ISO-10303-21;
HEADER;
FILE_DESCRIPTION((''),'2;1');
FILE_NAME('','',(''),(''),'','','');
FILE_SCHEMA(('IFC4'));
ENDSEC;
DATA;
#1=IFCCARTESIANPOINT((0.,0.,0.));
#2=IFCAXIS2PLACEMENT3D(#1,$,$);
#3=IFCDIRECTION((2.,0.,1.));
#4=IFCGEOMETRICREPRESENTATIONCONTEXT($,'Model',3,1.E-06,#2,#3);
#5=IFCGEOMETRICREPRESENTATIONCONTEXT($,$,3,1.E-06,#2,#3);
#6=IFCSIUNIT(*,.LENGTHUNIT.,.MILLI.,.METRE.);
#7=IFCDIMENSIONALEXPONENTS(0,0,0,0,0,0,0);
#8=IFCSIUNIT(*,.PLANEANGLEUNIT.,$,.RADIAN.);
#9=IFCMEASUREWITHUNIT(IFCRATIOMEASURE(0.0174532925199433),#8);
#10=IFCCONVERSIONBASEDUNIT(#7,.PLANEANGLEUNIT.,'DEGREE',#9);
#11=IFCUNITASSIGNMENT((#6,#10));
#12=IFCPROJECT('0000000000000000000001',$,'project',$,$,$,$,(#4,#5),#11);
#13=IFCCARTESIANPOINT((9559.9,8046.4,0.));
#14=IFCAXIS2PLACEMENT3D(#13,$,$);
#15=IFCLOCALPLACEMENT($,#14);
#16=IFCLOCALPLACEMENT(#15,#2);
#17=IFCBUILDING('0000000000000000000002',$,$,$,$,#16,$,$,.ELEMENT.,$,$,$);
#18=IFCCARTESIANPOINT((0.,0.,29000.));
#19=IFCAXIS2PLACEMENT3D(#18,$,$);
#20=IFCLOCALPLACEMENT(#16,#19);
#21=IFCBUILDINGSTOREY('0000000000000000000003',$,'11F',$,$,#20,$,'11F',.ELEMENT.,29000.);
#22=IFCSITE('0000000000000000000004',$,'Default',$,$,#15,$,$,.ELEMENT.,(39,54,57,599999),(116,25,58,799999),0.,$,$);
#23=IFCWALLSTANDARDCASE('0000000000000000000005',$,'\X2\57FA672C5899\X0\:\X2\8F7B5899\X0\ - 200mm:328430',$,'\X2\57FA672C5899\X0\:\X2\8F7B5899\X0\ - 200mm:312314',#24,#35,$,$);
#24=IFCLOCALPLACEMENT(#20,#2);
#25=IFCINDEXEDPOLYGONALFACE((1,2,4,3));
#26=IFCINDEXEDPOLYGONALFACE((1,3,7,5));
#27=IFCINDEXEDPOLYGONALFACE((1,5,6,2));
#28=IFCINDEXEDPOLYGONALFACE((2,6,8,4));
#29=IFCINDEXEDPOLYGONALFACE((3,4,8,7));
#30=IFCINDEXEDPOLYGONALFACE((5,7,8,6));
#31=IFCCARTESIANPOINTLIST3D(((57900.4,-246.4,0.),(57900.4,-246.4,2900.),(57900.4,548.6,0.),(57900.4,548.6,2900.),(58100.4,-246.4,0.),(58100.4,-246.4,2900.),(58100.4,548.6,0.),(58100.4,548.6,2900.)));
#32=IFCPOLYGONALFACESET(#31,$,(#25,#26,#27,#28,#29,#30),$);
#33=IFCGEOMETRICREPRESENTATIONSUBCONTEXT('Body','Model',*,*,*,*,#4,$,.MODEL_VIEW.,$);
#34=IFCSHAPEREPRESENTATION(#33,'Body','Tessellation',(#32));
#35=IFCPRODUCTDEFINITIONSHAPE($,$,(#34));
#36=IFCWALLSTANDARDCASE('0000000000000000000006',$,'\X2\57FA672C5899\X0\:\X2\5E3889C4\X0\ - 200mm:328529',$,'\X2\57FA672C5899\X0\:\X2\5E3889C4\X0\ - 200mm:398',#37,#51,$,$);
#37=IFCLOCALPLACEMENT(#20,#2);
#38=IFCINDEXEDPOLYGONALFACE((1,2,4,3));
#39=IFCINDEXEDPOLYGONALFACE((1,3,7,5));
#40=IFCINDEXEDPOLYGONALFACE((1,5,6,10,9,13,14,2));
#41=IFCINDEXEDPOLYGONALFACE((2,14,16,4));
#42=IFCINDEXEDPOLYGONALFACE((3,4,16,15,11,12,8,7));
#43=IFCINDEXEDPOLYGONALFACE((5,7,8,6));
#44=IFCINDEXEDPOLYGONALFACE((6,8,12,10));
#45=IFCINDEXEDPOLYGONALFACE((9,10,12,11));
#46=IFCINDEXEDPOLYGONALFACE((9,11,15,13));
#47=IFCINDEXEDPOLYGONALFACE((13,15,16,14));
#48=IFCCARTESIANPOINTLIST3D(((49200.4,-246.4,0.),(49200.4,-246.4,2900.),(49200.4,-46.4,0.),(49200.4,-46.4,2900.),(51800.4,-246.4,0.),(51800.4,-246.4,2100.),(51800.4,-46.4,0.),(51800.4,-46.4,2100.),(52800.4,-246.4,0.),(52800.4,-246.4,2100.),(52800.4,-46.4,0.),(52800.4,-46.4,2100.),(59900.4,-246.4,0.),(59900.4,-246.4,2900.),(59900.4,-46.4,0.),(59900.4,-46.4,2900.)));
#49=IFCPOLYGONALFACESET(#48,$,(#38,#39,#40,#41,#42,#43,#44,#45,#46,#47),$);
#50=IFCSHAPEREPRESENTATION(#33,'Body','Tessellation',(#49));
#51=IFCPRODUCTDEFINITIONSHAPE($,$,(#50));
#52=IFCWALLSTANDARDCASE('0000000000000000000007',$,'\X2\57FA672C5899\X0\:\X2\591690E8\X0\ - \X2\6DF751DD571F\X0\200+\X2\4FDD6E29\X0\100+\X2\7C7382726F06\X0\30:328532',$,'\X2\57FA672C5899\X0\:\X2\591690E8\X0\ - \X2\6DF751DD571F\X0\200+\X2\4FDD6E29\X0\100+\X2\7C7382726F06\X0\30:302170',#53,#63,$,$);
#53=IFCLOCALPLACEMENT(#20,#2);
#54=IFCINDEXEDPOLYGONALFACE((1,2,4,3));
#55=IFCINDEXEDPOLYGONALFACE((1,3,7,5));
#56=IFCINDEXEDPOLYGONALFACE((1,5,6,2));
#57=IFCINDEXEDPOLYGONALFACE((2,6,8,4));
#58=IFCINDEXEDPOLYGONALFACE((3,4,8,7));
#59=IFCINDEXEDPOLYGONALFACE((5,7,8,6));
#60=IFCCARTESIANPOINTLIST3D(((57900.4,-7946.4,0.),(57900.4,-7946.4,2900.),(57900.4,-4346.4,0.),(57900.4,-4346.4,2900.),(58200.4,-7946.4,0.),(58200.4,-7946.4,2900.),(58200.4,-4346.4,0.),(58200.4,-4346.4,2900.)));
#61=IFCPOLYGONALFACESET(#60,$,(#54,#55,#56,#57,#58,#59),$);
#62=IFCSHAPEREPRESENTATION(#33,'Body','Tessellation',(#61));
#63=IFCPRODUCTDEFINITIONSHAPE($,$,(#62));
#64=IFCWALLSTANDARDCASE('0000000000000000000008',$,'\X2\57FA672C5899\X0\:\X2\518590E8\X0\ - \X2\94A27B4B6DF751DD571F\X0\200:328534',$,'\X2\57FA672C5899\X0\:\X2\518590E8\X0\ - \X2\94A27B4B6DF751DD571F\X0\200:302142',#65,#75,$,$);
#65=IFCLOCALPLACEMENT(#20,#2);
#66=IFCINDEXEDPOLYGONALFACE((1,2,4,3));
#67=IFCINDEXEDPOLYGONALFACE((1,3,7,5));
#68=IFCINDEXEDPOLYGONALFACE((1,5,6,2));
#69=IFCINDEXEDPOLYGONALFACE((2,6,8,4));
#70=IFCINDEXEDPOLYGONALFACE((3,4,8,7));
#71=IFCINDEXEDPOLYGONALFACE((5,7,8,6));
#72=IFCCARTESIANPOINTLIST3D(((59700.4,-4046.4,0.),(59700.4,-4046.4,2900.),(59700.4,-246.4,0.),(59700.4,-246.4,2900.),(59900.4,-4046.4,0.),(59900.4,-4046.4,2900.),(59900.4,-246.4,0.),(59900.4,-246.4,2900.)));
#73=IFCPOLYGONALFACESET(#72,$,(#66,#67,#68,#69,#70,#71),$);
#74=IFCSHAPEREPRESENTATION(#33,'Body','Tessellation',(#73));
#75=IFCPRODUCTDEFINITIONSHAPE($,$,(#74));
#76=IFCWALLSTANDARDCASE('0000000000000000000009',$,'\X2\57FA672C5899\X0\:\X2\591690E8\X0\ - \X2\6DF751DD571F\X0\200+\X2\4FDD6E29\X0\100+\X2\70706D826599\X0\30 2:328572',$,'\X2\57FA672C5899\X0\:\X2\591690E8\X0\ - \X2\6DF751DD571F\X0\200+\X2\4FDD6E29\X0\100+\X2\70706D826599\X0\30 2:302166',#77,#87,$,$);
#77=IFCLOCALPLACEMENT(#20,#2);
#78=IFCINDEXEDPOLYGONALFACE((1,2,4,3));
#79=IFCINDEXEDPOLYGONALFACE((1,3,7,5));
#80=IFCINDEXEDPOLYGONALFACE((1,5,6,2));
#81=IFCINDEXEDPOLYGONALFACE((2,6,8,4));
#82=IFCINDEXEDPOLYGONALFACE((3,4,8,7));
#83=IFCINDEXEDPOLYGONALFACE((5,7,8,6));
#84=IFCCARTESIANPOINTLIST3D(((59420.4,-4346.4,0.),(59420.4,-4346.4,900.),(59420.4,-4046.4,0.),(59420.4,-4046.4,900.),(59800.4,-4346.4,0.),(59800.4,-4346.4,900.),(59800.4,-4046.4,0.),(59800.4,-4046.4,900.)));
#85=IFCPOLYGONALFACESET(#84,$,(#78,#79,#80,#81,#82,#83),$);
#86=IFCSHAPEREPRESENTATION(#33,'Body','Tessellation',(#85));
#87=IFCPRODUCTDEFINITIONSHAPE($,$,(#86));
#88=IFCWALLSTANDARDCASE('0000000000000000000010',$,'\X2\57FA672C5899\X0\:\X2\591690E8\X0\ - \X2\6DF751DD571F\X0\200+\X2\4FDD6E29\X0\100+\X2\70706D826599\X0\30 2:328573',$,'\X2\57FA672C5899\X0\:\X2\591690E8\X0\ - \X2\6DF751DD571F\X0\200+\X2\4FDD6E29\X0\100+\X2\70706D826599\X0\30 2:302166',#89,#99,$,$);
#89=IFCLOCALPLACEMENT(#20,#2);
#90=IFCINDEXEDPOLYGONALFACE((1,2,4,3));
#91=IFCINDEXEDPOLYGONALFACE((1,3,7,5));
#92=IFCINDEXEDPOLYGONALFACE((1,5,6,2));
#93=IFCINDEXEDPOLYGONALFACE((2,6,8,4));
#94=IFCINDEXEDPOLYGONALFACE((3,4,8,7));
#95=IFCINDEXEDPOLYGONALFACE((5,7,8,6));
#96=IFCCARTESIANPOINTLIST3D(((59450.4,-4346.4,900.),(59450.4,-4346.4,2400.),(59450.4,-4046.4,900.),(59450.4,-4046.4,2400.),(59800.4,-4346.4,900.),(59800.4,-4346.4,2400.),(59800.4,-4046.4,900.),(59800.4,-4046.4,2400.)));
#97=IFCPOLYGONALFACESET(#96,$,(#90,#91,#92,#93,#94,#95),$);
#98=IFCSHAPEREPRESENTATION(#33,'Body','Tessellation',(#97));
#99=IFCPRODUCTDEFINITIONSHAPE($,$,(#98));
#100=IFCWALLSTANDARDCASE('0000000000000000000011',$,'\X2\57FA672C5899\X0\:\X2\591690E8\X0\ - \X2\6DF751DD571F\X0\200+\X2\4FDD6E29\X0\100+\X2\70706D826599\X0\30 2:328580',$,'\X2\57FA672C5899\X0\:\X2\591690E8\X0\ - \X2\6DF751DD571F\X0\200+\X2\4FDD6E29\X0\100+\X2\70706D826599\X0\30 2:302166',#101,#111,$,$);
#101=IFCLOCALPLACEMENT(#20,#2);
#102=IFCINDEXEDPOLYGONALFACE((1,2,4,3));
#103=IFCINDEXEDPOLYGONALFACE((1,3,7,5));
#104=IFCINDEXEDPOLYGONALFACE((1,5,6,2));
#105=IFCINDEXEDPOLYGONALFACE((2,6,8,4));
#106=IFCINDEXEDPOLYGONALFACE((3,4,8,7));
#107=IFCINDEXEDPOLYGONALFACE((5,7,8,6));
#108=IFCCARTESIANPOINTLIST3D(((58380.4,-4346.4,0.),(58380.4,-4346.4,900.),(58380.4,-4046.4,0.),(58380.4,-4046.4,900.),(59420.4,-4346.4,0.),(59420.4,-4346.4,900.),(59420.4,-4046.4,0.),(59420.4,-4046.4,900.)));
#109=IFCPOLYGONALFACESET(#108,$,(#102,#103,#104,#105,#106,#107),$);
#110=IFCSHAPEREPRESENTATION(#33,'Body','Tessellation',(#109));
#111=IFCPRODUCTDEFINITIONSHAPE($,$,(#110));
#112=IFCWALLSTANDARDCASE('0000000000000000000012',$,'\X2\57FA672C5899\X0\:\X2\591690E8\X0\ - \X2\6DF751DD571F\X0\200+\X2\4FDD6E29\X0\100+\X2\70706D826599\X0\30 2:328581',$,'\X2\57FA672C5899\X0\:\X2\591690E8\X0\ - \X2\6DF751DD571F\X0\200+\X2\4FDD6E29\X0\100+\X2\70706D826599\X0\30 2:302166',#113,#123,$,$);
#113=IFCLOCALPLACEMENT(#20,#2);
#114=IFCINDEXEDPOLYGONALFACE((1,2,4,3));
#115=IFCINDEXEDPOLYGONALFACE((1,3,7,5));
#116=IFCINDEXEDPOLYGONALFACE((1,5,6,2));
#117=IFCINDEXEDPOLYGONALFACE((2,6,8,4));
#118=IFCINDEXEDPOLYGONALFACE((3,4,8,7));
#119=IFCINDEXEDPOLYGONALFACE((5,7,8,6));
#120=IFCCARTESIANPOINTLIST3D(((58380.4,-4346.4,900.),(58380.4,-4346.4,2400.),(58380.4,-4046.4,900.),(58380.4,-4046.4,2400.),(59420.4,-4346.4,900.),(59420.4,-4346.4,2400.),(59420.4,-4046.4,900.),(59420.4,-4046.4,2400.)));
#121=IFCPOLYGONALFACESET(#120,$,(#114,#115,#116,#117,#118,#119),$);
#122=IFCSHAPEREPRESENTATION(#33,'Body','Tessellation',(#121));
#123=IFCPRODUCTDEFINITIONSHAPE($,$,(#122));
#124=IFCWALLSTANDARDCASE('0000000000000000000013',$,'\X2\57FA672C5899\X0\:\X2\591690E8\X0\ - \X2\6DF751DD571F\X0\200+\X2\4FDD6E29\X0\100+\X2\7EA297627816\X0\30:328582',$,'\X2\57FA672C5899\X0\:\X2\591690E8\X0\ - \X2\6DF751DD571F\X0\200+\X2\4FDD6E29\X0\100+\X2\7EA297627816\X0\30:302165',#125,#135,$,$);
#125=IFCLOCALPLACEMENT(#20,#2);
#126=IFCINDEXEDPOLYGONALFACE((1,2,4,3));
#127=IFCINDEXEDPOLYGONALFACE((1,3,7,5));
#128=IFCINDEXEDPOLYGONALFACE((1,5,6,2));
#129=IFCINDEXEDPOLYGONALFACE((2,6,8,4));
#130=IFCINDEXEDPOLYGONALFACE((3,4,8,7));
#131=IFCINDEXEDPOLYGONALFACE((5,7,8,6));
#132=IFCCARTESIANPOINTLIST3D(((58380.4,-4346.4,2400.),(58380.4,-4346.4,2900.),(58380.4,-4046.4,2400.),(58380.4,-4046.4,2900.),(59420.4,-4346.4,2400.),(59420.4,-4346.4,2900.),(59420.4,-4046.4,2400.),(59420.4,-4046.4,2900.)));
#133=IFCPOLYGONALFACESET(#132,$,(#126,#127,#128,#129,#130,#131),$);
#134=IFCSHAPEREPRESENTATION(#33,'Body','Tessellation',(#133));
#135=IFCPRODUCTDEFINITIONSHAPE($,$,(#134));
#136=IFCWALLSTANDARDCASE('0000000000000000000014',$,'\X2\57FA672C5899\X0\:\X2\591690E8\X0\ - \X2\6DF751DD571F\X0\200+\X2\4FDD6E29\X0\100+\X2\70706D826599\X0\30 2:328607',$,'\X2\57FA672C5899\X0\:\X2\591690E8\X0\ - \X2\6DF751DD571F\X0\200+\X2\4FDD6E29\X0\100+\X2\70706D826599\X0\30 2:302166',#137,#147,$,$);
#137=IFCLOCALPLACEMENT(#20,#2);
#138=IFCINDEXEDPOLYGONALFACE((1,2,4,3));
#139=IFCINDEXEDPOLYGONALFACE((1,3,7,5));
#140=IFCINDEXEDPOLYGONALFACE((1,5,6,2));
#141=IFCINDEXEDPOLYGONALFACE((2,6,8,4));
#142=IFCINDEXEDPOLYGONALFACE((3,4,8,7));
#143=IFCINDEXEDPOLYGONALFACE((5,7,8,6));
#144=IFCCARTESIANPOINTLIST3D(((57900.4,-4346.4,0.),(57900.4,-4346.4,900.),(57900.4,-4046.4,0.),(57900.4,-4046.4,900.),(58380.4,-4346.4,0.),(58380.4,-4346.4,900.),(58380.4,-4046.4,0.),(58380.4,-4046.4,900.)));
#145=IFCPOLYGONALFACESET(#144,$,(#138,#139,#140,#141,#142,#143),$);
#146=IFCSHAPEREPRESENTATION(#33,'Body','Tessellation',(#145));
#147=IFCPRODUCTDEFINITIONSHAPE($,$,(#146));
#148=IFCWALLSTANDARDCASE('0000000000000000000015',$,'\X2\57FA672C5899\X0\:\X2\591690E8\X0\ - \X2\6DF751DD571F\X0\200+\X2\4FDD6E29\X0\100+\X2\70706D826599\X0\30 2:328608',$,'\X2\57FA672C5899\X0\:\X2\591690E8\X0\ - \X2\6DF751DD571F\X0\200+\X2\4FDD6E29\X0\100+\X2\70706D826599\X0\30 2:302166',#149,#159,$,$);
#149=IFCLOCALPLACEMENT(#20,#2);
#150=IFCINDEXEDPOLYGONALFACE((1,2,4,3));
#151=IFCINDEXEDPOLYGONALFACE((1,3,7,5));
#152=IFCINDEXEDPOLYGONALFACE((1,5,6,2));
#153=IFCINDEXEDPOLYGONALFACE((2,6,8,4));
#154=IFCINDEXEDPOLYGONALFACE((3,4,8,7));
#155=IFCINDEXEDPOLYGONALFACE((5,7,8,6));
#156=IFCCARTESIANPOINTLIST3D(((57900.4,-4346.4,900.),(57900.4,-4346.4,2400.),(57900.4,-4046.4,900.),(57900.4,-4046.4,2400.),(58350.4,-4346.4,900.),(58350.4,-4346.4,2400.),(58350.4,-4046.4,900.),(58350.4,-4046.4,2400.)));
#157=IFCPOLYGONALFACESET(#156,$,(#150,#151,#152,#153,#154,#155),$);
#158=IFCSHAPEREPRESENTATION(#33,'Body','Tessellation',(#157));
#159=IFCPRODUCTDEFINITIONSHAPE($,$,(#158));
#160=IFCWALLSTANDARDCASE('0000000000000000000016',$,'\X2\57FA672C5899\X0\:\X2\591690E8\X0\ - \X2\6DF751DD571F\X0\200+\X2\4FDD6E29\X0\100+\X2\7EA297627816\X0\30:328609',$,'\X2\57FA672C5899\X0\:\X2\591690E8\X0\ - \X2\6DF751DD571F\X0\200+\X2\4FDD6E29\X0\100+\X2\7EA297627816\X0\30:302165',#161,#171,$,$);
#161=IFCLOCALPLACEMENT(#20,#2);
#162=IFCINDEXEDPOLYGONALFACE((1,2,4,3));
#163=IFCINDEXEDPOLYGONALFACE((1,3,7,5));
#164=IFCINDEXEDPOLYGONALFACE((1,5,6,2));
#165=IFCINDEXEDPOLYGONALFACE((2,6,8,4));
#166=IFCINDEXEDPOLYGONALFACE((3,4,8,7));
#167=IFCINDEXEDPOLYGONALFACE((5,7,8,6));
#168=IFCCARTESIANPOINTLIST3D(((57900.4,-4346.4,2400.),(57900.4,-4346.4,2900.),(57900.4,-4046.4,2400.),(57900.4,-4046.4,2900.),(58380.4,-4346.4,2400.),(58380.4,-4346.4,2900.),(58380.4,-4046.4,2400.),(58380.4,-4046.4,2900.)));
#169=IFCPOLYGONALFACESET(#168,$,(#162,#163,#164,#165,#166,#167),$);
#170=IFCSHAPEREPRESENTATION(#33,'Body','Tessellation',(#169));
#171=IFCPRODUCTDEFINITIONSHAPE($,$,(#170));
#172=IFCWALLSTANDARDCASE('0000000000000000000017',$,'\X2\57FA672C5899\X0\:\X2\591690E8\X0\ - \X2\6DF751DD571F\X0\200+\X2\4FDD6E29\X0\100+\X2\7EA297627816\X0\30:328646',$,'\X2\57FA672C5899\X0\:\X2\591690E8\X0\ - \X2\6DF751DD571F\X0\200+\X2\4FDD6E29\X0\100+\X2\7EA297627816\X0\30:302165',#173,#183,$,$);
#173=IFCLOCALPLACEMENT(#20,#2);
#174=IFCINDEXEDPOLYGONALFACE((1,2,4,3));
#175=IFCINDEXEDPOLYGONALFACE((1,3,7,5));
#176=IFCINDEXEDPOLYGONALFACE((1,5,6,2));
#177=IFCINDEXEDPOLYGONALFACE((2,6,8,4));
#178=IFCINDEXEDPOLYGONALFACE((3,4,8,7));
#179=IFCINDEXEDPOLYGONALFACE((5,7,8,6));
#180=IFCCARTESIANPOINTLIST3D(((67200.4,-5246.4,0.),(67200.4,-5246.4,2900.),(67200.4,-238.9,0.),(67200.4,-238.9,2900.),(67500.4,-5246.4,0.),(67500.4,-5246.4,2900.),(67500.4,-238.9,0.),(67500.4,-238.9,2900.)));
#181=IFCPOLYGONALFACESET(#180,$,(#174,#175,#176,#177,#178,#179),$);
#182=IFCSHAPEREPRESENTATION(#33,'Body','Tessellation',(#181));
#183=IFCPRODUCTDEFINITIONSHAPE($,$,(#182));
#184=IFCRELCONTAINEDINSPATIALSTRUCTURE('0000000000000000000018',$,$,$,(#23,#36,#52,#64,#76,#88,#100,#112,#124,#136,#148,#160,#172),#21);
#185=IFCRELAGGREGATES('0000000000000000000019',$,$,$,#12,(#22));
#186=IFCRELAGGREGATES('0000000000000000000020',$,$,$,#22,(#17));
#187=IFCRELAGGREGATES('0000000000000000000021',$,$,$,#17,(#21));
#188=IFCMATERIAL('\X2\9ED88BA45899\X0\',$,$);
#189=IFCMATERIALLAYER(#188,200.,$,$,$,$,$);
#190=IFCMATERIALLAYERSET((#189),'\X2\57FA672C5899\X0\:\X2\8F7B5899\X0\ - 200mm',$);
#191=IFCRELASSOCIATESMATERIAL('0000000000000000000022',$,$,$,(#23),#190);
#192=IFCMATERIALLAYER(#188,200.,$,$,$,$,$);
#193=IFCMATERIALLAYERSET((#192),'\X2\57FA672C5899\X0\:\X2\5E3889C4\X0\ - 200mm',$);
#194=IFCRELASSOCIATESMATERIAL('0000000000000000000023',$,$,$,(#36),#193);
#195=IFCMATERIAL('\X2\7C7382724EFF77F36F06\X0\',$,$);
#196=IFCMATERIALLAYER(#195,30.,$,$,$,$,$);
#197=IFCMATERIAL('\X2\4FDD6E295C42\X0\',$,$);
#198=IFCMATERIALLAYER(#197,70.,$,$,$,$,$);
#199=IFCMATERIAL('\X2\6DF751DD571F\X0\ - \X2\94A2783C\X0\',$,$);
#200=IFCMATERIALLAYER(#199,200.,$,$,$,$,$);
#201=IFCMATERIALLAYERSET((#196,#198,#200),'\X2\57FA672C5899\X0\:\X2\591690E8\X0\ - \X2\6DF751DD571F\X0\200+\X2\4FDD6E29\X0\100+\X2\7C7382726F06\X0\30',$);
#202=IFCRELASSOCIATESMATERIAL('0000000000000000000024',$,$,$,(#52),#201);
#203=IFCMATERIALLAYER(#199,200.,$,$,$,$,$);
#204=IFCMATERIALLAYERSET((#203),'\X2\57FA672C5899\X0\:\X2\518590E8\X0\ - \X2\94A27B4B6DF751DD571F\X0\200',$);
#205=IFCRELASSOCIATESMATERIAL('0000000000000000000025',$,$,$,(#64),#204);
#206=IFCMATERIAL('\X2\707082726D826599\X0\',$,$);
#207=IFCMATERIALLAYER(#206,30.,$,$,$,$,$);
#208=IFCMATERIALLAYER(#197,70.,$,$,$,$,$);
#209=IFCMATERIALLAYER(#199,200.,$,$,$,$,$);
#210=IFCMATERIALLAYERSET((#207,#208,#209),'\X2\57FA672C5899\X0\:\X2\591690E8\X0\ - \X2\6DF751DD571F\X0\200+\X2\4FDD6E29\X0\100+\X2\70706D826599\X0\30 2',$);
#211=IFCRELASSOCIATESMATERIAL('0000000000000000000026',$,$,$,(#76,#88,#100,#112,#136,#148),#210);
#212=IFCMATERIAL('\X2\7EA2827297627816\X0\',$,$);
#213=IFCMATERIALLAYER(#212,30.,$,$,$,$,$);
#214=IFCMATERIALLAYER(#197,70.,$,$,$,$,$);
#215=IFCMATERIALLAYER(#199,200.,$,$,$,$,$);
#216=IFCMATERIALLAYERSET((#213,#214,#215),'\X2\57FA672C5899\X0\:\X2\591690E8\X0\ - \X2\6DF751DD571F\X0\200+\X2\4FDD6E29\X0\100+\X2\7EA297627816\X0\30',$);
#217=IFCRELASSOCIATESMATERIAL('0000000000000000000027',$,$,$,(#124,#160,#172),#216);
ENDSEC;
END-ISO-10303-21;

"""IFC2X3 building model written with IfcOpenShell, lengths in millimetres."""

from ifc_helpers import new_model, entity, si_unit, converted_unit, direction, frame, frame_2d, origin, place, context, subcontext, project, spatial, rectangle, extrude, material, layer, layer_set, layer_usage, element, save


model = new_model("IFC2X3")

# Units and contexts
model_context = context("Model", 3, precision=1e-06, world=origin(), true_north=direction((2.0, 0.0, 1.0)))
context_of_model = context(None, 3, precision=1e-06, world=origin(), true_north=direction((2.0, 0.0, 1.0)))
body_context = subcontext(model_context, "Body", "Model", "MODEL_VIEW")
ifc_project = project(units=[si_unit("LENGTHUNIT", "METRE", prefix="MILLI"), converted_unit("PLANEANGLEUNIT", "DEGREE", entity("IfcRatioMeasure", 0.0174532925199433), si_unit("PLANEANGLEUNIT", "RADIAN"), dimensions=[0, 0, 0, 0, 0, 0, 0])], contexts=[model_context, context_of_model])

# Site, building, storey
site_placement = place(None, frame((9559.9, 8046.4, 0.0)))
site = spatial("IfcSite", under=ifc_project, at=site_placement, Name="Default", CompositionType="ELEMENT", RefLatitude=(39, 54, 57, 599999), RefLongitude=(116, 25, 58, 799999), RefElevation=0.0)
building_placement = place(site_placement, origin())
building = spatial("IfcBuilding", under=site, at=building_placement, CompositionType="ELEMENT")
storey_placement = place(building_placement, frame((0.0, 0.0, 29000.0)))
storey = spatial("IfcBuildingStorey", under=building, at=storey_placement, Name="11F", LongName="11F", CompositionType="ELEMENT", Elevation=29000.0)

# Wall
ifc_material_1 = material(Name="默认墙")
ifc_layer_1 = layer(ifc_material_1, 200.0)
ifc_layer_set_1 = layer_set([ifc_layer_1], Name="基本墙:轻墙 - 200mm")
ifc_layer_usage_1 = layer_usage(ifc_layer_set_1, "AXIS2", "POSITIVE", -100.0)
wall_1_placement = place(storey_placement, frame((58000.4, -246.4, 0.0), z_axis=(0.0, 0.0, 1.0), x_axis=(0.0, 1.0, 0.0)))
element("IfcWallStandardCase", 1, at=wall_1_placement, inside=storey, material=ifc_layer_usage_1, Name="基本墙:轻墙 - 200mm:328430", ObjectType="基本墙:轻墙 - 200mm:312314", context=body_context, shape_type="SweptSolid", body=[
    extrude(rectangle(XDim=795.0, YDim=200.0, at=frame_2d((397.5, 0.0), x_axis=(-1.0, 0.0))), origin(), (0.0, 0.0, 1.0), 2900.0),
])

# Wall, opening
ifc_layer_2 = layer(ifc_material_1, 200.0)
ifc_layer_set_2 = layer_set([ifc_layer_2], Name="基本墙:常规 - 200mm")
ifc_layer_usage_2 = layer_usage(ifc_layer_set_2, "AXIS2", "POSITIVE", -100.0)
wall_2_placement = place(storey_placement, frame((59900.4, -146.4, 0.0), z_axis=(0.0, 0.0, 1.0), x_axis=(-1.0, 0.0, 0.0)))
wall_2 = element("IfcWallStandardCase", 2, at=wall_2_placement, inside=storey, material=ifc_layer_usage_2, Name="基本墙:常规 - 200mm:328529", ObjectType="基本墙:常规 - 200mm:398", context=body_context, shape_type="SweptSolid", body=[
    extrude(rectangle(XDim=10700.0, YDim=200.0, at=frame_2d((5350.0, 0.0), x_axis=(-1.0, 0.0))), origin(), (0.0, 0.0, 1.0), 2900.0),
])
opening_1_placement = place(wall_2_placement, frame((8100.0, 100.0, 0.0)))
element("IfcOpeningElement", 3, at=opening_1_placement, cuts=wall_2, ObjectType="Opening", context=body_context, shape_type="SweptSolid", body=[
    extrude(rectangle(XDim=2100.0, YDim=1000.0, at=frame_2d((1050.0, 500.0), x_axis=(1.0, 0.0))), frame((0.0, 0.0, 0.0), z_axis=(0.0, -1.0, 0.0), x_axis=(0.0, 0.0, 1.0)), (0.0, 0.0, 1.0), 200.0),
])

# Walls
ifc_material_2 = material(Name="米色仿石漆")
ifc_layer_3 = layer(ifc_material_2, 30.0)
ifc_material_3 = material(Name="保温层")
ifc_layer_4 = layer(ifc_material_3, 70.0)
ifc_material_4 = material(Name="混凝土 - 钢砼")
ifc_layer_5 = layer(ifc_material_4, 200.0)
ifc_layer_set_3 = layer_set([ifc_layer_3, ifc_layer_4, ifc_layer_5], Name="基本墙:外部 - 混凝土200+保温100+米色漆30")
ifc_layer_usage_3 = layer_usage(ifc_layer_set_3, "AXIS2", "POSITIVE", -150.0)
wall_3_placement = place(storey_placement, frame((58050.4, -7946.4, 0.0), z_axis=(0.0, 0.0, 1.0), x_axis=(0.0, 1.0, 0.0)))
element("IfcWallStandardCase", 4, at=wall_3_placement, inside=storey, material=ifc_layer_usage_3, Name="基本墙:外部 - 混凝土200+保温100+米色漆30:328532", ObjectType="基本墙:外部 - 混凝土200+保温100+米色漆30:302170", context=body_context, shape_type="SweptSolid", body=[
    extrude(rectangle(XDim=3600.0, YDim=300.0, at=frame_2d((1800.0, 0.0), x_axis=(-1.0, 0.0))), origin(), (0.0, 0.0, 1.0), 2900.0),
])
ifc_layer_6 = layer(ifc_material_4, 200.0)
ifc_layer_set_4 = layer_set([ifc_layer_6], Name="基本墙:内部 - 钢筋混凝土200")
ifc_layer_usage_4 = layer_usage(ifc_layer_set_4, "AXIS2", "POSITIVE", -100.0)
wall_4_placement = place(storey_placement, frame((59800.4, -4046.4, 0.0), z_axis=(0.0, 0.0, 1.0), x_axis=(0.0, 1.0, 0.0)))
element("IfcWallStandardCase", 5, at=wall_4_placement, inside=storey, material=ifc_layer_usage_4, Name="基本墙:内部 - 钢筋混凝土200:328534", ObjectType="基本墙:内部 - 钢筋混凝土200:302142", context=body_context, shape_type="SweptSolid", body=[
    extrude(rectangle(XDim=3800.0, YDim=200.0, at=frame_2d((1900.0, 0.0), x_axis=(-1.0, 0.0))), origin(), (0.0, 0.0, 1.0), 2900.0),
])
ifc_material_5 = material(Name="灰色涂料")
ifc_layer_7 = layer(ifc_material_5, 30.0)
ifc_layer_8 = layer(ifc_material_3, 70.0)
ifc_layer_9 = layer(ifc_material_4, 200.0)
ifc_layer_set_5 = layer_set([ifc_layer_7, ifc_layer_8, ifc_layer_9], Name="基本墙:外部 - 混凝土200+保温100+灰涂料30 2")
ifc_layer_usage_5 = layer_usage(ifc_layer_set_5, "AXIS2", "POSITIVE", -150.0)
wall_5_placement = place(storey_placement, frame((59420.4, -4196.4, 0.0)))
element("IfcWallStandardCase", 6, at=wall_5_placement, inside=storey, material=ifc_layer_usage_5, Name="基本墙:外部 - 混凝土200+保温100+灰涂料30 2:328572", ObjectType="基本墙:外部 - 混凝土200+保温100+灰涂料30 2:302166", context=body_context, shape_type="SweptSolid", body=[
    extrude(rectangle(XDim=380.0, YDim=300.0, at=frame_2d((190.0, 0.0), x_axis=(-1.0, 0.0))), origin(), (0.0, 0.0, 1.0), 900.0),
])
ifc_layer_usage_6 = layer_usage(ifc_layer_set_5, "AXIS2", "POSITIVE", -150.0)
wall_6_placement = place(storey_placement, frame((59450.4, -4196.4, 900.0)))
element("IfcWallStandardCase", 7, at=wall_6_placement, inside=storey, material=ifc_layer_usage_6, Name="基本墙:外部 - 混凝土200+保温100+灰涂料30 2:328573", ObjectType="基本墙:外部 - 混凝土200+保温100+灰涂料30 2:302166", context=body_context, shape_type="SweptSolid", body=[
    extrude(rectangle(XDim=350.0, YDim=300.0, at=frame_2d((175.0, 0.0), x_axis=(-1.0, 0.0))), origin(), (0.0, 0.0, 1.0), 1500.0),
])

# Shared definitions
ifc_material_6 = material(Name="红色面砖")
ifc_layer_10 = layer(ifc_material_6, 30.0)
ifc_layer_11 = layer(ifc_material_3, 70.0)
ifc_layer_12 = layer(ifc_material_4, 200.0)
ifc_layer_set_6 = layer_set([ifc_layer_10, ifc_layer_11, ifc_layer_12], Name="基本墙:外部 - 混凝土200+保温100+红面砖30")

# Walls
ifc_layer_usage_7 = layer_usage(ifc_layer_set_5, "AXIS2", "POSITIVE", -150.0)
wall_7_placement = place(storey_placement, frame((58380.4, -4196.4, 0.0)))
element("IfcWallStandardCase", 8, at=wall_7_placement, inside=storey, material=ifc_layer_usage_7, Name="基本墙:外部 - 混凝土200+保温100+灰涂料30 2:328580", ObjectType="基本墙:外部 - 混凝土200+保温100+灰涂料30 2:302166", context=body_context, shape_type="SweptSolid", body=[
    extrude(rectangle(XDim=1040.0, YDim=300.0, at=frame_2d((520.0, 0.0), x_axis=(-1.0, 0.0))), origin(), (0.0, 0.0, 1.0), 900.0),
])
ifc_layer_usage_8 = layer_usage(ifc_layer_set_5, "AXIS2", "POSITIVE", -150.0)
wall_8_placement = place(storey_placement, frame((58380.4, -4196.4, 900.0)))
element("IfcWallStandardCase", 9, at=wall_8_placement, inside=storey, material=ifc_layer_usage_8, Name="基本墙:外部 - 混凝土200+保温100+灰涂料30 2:328581", ObjectType="基本墙:外部 - 混凝土200+保温100+灰涂料30 2:302166", context=body_context, shape_type="SweptSolid", body=[
    extrude(rectangle(XDim=1040.0, YDim=300.0, at=frame_2d((520.0, 0.0), x_axis=(-1.0, 0.0))), origin(), (0.0, 0.0, 1.0), 1500.0),
])
ifc_layer_usage_9 = layer_usage(ifc_layer_set_6, "AXIS2", "POSITIVE", -150.0)
wall_9_placement = place(storey_placement, frame((58380.4, -4196.4, 2400.0)))
element("IfcWallStandardCase", 10, at=wall_9_placement, inside=storey, material=ifc_layer_usage_9, Name="基本墙:外部 - 混凝土200+保温100+红面砖30:328582", ObjectType="基本墙:外部 - 混凝土200+保温100+红面砖30:302165", context=body_context, shape_type="SweptSolid", body=[
    extrude(rectangle(XDim=1040.0, YDim=300.0, at=frame_2d((520.0, 0.0), x_axis=(-1.0, 0.0))), origin(), (0.0, 0.0, 1.0), 500.0),
])
ifc_layer_usage_10 = layer_usage(ifc_layer_set_5, "AXIS2", "POSITIVE", -150.0)
wall_10_placement = place(storey_placement, frame((57900.4, -4196.4, 0.0)))
element("IfcWallStandardCase", 11, at=wall_10_placement, inside=storey, material=ifc_layer_usage_10, Name="基本墙:外部 - 混凝土200+保温100+灰涂料30 2:328607", ObjectType="基本墙:外部 - 混凝土200+保温100+灰涂料30 2:302166", context=body_context, shape_type="SweptSolid", body=[
    extrude(rectangle(XDim=480.0, YDim=300.0, at=frame_2d((240.0, 0.0), x_axis=(-1.0, 0.0))), origin(), (0.0, 0.0, 1.0), 900.0),
])
ifc_layer_usage_11 = layer_usage(ifc_layer_set_5, "AXIS2", "POSITIVE", -150.0)
wall_11_placement = place(storey_placement, frame((57900.4, -4196.4, 900.0)))
element("IfcWallStandardCase", 12, at=wall_11_placement, inside=storey, material=ifc_layer_usage_11, Name="基本墙:外部 - 混凝土200+保温100+灰涂料30 2:328608", ObjectType="基本墙:外部 - 混凝土200+保温100+灰涂料30 2:302166", context=body_context, shape_type="SweptSolid", body=[
    extrude(rectangle(XDim=450.0, YDim=300.0, at=frame_2d((225.0, 0.0), x_axis=(-1.0, 0.0))), origin(), (0.0, 0.0, 1.0), 1500.0),
])
ifc_layer_usage_12 = layer_usage(ifc_layer_set_6, "AXIS2", "POSITIVE", -150.0)
wall_12_placement = place(storey_placement, frame((57900.4, -4196.4, 2400.0)))
element("IfcWallStandardCase", 13, at=wall_12_placement, inside=storey, material=ifc_layer_usage_12, Name="基本墙:外部 - 混凝土200+保温100+红面砖30:328609", ObjectType="基本墙:外部 - 混凝土200+保温100+红面砖30:302165", context=body_context, shape_type="SweptSolid", body=[
    extrude(rectangle(XDim=480.0, YDim=300.0, at=frame_2d((240.0, 0.0), x_axis=(-1.0, 0.0))), origin(), (0.0, 0.0, 1.0), 500.0),
])
ifc_layer_usage_13 = layer_usage(ifc_layer_set_6, "AXIS2", "POSITIVE", -150.0)
wall_13_placement = place(storey_placement, frame((67350.4, -5246.4, 0.0), z_axis=(0.0, 0.0, 1.0), x_axis=(0.0, 1.0, 0.0)))
element("IfcWallStandardCase", 14, at=wall_13_placement, inside=storey, material=ifc_layer_usage_13, Name="基本墙:外部 - 混凝土200+保温100+红面砖30:328646", ObjectType="基本墙:外部 - 混凝土200+保温100+红面砖30:302165", context=body_context, shape_type="SweptSolid", body=[
    extrude(rectangle(XDim=5007.5, YDim=300.0, at=frame_2d((2503.8, 0.0), x_axis=(-1.0, 0.0))), origin(), (0.0, 0.0, 1.0), 2900.0),
])

save(model, "model.ifc")
